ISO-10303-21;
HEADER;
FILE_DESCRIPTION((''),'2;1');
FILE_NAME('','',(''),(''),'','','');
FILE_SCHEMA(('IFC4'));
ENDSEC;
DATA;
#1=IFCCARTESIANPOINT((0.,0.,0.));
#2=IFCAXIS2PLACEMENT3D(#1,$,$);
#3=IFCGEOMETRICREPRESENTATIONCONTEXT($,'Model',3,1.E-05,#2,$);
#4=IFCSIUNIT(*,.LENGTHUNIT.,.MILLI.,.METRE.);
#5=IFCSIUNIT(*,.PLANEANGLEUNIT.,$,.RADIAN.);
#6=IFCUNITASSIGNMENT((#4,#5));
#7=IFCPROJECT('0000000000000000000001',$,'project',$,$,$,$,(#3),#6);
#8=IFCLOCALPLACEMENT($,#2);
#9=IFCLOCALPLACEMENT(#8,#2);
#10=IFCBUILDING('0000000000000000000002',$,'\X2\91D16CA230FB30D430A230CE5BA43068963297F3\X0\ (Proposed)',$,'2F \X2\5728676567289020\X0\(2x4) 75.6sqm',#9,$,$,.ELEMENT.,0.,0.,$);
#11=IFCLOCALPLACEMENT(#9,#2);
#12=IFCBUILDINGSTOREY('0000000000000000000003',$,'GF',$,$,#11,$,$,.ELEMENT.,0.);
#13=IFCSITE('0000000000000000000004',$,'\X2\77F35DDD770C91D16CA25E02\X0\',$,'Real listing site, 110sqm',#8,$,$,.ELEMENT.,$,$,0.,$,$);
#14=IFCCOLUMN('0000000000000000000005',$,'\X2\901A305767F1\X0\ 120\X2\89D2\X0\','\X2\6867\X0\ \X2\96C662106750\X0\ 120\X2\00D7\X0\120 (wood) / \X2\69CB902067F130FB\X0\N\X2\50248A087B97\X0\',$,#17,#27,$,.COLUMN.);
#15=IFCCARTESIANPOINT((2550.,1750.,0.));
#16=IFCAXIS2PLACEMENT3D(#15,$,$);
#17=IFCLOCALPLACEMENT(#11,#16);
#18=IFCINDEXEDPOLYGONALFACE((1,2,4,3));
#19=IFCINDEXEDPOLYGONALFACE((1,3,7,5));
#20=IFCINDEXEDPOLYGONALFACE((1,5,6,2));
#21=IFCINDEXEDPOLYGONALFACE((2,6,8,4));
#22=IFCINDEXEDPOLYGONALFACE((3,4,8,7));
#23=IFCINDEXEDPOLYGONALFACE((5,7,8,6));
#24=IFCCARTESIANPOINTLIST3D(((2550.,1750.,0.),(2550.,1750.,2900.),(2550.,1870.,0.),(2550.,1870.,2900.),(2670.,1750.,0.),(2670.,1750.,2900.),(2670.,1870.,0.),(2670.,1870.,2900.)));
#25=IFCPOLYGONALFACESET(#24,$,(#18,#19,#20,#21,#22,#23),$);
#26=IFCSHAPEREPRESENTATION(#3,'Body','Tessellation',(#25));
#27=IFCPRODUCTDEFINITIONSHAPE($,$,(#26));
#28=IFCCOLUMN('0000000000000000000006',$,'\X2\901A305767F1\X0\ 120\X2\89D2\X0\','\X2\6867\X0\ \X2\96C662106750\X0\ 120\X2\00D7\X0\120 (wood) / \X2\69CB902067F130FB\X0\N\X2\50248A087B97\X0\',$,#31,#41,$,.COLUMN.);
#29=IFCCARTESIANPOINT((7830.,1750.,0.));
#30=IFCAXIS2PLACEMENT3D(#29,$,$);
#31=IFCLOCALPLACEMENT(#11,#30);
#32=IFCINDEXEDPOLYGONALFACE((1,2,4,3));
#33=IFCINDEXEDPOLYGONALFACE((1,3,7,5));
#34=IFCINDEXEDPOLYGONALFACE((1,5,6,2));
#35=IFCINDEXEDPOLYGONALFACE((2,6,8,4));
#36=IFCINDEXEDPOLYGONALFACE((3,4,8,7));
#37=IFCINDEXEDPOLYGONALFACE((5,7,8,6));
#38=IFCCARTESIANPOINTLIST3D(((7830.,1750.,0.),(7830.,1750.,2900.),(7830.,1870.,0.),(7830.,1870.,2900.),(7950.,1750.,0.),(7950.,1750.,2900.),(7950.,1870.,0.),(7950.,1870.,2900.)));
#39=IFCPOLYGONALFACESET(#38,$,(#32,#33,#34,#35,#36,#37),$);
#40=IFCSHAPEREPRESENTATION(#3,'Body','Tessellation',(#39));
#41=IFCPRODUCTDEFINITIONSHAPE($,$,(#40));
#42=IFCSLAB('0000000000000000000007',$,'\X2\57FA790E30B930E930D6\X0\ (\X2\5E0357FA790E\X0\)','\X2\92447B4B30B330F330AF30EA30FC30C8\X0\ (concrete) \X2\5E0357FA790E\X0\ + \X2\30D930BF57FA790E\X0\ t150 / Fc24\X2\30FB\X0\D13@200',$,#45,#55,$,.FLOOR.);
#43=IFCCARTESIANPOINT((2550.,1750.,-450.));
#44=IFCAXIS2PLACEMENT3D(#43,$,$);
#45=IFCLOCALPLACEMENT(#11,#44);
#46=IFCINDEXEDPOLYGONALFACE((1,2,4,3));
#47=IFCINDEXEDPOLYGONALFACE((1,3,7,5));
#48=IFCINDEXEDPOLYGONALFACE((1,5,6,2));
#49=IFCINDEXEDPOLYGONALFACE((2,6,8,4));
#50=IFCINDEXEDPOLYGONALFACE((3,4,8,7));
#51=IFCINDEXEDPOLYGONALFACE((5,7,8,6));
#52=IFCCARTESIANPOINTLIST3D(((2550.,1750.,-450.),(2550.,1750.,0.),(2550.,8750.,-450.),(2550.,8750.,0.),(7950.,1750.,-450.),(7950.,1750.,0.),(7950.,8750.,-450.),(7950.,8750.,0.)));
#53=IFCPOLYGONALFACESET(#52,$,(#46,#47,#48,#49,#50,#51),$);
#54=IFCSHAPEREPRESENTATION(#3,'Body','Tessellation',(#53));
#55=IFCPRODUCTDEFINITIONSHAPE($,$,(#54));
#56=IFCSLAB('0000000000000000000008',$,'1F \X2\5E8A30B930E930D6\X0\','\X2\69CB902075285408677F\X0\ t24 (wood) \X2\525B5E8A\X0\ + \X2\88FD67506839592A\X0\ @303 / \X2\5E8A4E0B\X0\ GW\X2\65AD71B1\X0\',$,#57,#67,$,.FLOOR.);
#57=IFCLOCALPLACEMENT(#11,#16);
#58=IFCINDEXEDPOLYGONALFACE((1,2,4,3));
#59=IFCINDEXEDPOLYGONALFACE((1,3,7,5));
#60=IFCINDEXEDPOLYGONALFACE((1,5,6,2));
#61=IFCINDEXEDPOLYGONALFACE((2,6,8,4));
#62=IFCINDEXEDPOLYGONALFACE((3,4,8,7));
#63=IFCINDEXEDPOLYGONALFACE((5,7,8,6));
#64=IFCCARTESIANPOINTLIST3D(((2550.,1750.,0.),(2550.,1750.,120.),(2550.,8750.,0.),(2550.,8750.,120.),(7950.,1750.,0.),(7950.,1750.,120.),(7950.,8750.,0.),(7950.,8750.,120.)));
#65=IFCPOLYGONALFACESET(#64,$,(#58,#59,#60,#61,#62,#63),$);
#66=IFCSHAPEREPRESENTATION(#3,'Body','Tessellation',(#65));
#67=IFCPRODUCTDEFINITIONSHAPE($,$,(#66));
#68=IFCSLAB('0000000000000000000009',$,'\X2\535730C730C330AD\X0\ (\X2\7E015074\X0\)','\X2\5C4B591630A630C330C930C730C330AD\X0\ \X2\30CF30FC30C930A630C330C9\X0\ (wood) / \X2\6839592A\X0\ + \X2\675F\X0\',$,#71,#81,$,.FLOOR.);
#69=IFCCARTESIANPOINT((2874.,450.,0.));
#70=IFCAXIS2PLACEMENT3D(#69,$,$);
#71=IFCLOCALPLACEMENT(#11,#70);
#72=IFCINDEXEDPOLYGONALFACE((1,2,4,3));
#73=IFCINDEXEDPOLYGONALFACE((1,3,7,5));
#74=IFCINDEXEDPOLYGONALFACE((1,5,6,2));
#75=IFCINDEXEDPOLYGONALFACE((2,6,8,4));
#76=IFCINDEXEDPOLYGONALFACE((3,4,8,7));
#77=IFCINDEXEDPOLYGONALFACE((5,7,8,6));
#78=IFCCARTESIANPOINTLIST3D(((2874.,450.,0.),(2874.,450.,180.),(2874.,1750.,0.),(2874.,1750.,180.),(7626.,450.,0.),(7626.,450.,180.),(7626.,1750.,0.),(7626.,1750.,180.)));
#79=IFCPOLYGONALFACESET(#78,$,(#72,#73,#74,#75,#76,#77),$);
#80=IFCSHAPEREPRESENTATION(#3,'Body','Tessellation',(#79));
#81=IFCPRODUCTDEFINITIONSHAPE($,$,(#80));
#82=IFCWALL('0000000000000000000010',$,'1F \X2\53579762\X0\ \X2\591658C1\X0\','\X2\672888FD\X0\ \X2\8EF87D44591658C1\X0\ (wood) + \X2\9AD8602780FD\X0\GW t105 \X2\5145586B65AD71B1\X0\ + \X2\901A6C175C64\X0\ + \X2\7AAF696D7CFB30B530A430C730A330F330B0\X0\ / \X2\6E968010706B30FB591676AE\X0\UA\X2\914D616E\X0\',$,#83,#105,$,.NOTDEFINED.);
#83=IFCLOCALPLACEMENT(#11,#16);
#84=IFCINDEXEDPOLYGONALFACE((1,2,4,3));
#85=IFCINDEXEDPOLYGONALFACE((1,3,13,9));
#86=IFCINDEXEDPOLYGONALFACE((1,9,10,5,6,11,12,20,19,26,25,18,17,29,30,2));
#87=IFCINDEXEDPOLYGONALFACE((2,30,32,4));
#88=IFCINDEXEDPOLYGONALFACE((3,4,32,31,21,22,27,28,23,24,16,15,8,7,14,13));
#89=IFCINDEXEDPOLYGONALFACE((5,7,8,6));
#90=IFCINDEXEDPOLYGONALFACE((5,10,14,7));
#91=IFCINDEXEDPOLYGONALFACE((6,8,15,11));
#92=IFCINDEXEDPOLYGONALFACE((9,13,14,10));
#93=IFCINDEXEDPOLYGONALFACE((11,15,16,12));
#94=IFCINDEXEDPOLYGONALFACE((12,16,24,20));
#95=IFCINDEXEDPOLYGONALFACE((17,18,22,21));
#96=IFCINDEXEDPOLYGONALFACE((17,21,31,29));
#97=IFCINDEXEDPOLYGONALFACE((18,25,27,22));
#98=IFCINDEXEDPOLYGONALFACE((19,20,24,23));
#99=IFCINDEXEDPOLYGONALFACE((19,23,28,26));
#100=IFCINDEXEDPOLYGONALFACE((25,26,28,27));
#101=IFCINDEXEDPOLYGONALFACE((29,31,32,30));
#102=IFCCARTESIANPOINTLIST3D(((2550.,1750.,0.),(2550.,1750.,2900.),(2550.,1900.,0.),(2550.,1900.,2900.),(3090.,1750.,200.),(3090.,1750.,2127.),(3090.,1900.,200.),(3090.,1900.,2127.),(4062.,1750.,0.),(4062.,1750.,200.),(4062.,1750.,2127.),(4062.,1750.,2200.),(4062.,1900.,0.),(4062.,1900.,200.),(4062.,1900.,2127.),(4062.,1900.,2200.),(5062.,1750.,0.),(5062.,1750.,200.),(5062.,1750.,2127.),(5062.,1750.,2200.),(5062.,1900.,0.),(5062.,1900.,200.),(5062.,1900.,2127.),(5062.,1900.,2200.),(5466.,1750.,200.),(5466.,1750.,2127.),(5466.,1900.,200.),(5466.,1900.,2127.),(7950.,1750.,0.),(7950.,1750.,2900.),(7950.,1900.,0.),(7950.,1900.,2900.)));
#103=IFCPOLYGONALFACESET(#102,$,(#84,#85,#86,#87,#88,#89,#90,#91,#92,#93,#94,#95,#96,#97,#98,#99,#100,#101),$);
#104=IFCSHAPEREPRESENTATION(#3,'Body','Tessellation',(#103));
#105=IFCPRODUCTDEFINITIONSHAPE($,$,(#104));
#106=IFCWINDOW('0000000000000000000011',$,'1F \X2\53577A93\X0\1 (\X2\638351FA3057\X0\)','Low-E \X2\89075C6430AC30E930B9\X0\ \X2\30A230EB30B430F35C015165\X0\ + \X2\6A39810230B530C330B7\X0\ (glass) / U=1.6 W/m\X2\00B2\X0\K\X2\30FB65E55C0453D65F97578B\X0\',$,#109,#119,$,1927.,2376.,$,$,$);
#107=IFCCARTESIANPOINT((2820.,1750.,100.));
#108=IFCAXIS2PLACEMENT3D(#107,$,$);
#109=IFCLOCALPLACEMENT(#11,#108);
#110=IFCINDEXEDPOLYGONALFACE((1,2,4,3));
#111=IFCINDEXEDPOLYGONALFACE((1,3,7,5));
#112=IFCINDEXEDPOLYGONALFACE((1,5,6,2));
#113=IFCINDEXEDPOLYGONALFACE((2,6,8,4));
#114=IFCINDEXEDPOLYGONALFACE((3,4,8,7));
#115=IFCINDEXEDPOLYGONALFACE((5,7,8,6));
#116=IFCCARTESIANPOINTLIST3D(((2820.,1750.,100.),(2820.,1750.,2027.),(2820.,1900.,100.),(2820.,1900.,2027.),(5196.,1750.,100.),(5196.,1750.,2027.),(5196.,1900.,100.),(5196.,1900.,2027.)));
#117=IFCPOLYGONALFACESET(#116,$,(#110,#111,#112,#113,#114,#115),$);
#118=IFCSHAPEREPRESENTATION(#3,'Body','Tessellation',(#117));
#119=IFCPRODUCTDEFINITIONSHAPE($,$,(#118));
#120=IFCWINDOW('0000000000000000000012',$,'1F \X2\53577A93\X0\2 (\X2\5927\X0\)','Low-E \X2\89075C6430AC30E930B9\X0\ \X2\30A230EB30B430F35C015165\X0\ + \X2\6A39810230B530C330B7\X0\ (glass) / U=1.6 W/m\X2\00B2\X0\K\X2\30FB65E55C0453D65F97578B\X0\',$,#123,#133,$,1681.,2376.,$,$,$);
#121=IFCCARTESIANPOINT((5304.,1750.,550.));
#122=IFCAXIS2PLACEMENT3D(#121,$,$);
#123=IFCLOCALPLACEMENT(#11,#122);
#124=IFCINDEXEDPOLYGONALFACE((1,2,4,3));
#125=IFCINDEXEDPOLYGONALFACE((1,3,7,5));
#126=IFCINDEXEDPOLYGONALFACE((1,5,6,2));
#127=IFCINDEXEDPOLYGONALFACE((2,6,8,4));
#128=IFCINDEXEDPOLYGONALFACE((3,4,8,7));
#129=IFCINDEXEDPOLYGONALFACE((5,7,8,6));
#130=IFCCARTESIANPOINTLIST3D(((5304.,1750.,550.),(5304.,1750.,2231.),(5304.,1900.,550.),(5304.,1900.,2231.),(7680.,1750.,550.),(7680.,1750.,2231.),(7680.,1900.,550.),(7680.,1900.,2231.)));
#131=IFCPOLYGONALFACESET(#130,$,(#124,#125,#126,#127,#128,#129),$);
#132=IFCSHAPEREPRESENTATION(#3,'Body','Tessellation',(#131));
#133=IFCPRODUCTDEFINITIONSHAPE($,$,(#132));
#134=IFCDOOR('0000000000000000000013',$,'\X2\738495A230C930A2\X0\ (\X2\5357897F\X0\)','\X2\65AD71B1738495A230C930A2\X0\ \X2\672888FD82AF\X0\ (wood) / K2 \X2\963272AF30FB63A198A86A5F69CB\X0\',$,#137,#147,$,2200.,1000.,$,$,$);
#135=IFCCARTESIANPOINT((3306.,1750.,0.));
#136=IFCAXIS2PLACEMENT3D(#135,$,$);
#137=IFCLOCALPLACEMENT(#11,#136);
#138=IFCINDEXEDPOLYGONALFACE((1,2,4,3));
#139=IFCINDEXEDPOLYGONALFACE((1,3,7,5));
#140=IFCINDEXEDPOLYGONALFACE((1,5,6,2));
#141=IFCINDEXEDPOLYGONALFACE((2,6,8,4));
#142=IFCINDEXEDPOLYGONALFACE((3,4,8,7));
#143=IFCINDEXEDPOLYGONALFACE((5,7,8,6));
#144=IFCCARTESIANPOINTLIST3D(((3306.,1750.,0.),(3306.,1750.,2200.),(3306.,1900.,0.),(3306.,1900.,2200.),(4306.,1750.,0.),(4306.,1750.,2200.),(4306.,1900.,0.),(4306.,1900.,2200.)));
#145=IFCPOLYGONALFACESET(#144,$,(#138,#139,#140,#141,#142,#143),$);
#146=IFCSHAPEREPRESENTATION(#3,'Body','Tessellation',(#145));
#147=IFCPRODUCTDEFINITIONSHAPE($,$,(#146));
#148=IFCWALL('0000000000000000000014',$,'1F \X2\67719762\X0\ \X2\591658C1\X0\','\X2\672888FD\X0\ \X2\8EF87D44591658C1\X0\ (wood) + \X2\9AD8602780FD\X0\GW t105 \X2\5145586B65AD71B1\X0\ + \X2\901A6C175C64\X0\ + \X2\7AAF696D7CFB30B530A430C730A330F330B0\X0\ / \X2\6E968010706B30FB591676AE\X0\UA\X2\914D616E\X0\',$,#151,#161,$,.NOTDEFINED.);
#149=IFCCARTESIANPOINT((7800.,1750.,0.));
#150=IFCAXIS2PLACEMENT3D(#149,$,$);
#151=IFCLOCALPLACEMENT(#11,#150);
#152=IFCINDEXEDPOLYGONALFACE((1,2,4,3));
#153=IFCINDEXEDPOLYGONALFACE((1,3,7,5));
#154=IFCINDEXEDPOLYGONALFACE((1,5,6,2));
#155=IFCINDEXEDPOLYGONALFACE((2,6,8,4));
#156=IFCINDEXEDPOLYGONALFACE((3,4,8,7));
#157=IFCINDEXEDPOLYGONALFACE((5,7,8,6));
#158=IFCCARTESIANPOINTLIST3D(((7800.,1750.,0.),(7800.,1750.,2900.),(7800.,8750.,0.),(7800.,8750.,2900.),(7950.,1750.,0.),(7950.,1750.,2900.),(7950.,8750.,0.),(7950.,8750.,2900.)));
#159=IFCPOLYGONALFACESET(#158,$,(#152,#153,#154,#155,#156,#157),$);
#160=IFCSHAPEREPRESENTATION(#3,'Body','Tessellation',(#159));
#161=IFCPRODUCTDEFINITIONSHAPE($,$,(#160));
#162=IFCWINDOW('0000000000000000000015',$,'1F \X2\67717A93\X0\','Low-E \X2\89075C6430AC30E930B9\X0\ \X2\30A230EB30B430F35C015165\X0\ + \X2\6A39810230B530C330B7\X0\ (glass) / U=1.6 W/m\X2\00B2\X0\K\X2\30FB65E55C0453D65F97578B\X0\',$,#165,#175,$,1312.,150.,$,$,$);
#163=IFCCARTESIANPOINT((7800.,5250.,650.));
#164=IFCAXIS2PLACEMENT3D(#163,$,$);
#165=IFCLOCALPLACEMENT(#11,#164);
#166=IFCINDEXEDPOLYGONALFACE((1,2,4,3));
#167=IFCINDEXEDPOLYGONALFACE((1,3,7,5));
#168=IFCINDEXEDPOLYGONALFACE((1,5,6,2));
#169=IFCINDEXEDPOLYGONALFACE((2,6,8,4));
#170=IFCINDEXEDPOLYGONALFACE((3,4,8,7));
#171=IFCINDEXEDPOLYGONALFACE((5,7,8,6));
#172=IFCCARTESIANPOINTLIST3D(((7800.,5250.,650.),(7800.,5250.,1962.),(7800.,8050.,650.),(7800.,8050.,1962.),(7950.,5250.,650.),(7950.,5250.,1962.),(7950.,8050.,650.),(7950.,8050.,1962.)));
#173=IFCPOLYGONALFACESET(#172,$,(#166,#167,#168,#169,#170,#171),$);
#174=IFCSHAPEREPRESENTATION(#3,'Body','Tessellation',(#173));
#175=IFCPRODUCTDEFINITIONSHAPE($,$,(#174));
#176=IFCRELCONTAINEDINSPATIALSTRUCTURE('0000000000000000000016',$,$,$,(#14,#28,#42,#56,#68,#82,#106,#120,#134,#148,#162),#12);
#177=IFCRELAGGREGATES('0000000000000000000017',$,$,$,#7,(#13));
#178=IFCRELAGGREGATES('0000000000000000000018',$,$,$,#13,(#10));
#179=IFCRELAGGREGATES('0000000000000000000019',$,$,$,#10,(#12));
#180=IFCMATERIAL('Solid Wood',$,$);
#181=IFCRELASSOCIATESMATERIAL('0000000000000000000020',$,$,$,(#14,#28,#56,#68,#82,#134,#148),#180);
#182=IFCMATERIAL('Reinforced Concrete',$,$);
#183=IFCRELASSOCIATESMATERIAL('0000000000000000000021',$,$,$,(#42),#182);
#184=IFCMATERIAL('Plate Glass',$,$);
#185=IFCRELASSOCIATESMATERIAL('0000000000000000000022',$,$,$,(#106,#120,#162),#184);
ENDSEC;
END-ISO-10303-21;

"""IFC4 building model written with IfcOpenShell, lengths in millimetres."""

from ifc_helpers import new_model, si_unit, frame, frame_2d, origin, place, context, project, spatial, rectangle, extrude, material, element, fill, save


model = new_model("IFC4")

# Units and contexts
model_context = context("Model", 3, precision=1e-05, world=origin())
ifc_project = project(units=[si_unit("LENGTHUNIT", "METRE", prefix="MILLI"), si_unit("PLANEANGLEUNIT", "RADIAN")], contexts=[model_context])

# Site, building, storey
site_placement = place(None, origin())
site = spatial("IfcSite", under=ifc_project, at=site_placement, Name="石川県金沢市", ObjectType="Real listing site, 110sqm", CompositionType="ELEMENT", RefElevation=0.0)
building_placement = place(site_placement, origin())
building = spatial("IfcBuilding", under=site, at=building_placement, Name="金沢・ピアノ室と防音 (Proposed)", ObjectType="2F 在来木造(2x4) 75.6sqm", CompositionType="ELEMENT", ElevationOfRefHeight=0.0, ElevationOfTerrain=0.0)
storey_placement = place(building_placement, origin())
storey = spatial("IfcBuildingStorey", under=building, at=storey_placement, Name="GF", CompositionType="ELEMENT", Elevation=0.0)

# Columns
ifc_material_1 = material(Name="Solid Wood")
column_1_placement = place(storey_placement, frame((2550.0, 1750.0, 0.0)))
element("IfcColumn", 1, at=column_1_placement, inside=storey, material=ifc_material_1, Name="通し柱 120角", Description="桧 集成材 120×120 (wood) / 構造柱・N値計算", PredefinedType="COLUMN", context=model_context, shape_type="SweptSolid", body=[
    extrude(rectangle(XDim=120.0, YDim=120.0, at=frame_2d((60.0, 60.0))), frame((2550.0, 1750.0, 0.0)), (0.0, 0.0, 1.0), 2900.0),
])
column_2_placement = place(storey_placement, frame((7830.0, 1750.0, 0.0)))
element("IfcColumn", 2, at=column_2_placement, inside=storey, material=ifc_material_1, Name="通し柱 120角", Description="桧 集成材 120×120 (wood) / 構造柱・N値計算", PredefinedType="COLUMN", context=model_context, shape_type="SweptSolid", body=[
    extrude(rectangle(XDim=120.0, YDim=120.0, at=frame_2d((60.0, 60.0))), frame((7830.0, 1750.0, 0.0)), (0.0, 0.0, 1.0), 2900.0),
])

# Slabs
ifc_material_2 = material(Name="Reinforced Concrete")
slab_1_placement = place(storey_placement, frame((2550.0, 1750.0, -450.0)))
element("IfcSlab", 3, at=slab_1_placement, inside=storey, material=ifc_material_2, Name="基礎スラブ (布基礎)", Description="鉄筋コンクリート (concrete) 布基礎 + ベタ基礎 t150 / Fc24・D13@200", PredefinedType="FLOOR", context=model_context, shape_type="SweptSolid", body=[
    extrude(rectangle(XDim=5400.0, YDim=7000.0, at=frame_2d((2700.0, 3500.0))), frame((2550.0, 1750.0, -450.0)), (0.0, 0.0, 1.0), 450.0),
])
slab_2_placement = place(storey_placement, frame((2550.0, 1750.0, 0.0)))
element("IfcSlab", 4, at=slab_2_placement, inside=storey, material=ifc_material_1, Name="1F 床スラブ", Description="構造用合板 t24 (wood) 剛床 + 製材根太 @303 / 床下 GW断熱", PredefinedType="FLOOR", context=model_context, shape_type="SweptSolid", body=[
    extrude(rectangle(XDim=5400.0, YDim=7000.0, at=frame_2d((2700.0, 3500.0))), frame((2550.0, 1750.0, 0.0)), (0.0, 0.0, 1.0), 120.0),
])
slab_3_placement = place(storey_placement, frame((2874.0, 450.0, 0.0)))
element("IfcSlab", 5, at=slab_3_placement, inside=storey, material=ifc_material_1, Name="南デッキ (縁側)", Description="屋外ウッドデッキ ハードウッド (wood) / 根太 + 束", PredefinedType="FLOOR", context=model_context, shape_type="SweptSolid", body=[
    extrude(rectangle(XDim=4752.0, YDim=1300.0, at=frame_2d((2376.0, 650.0))), frame((2874.0, 450.0, 0.0)), (0.0, 0.0, 1.0), 180.0),
])

# Wall, openings, windows, door
wall_1_placement = place(storey_placement, frame((2550.0, 1750.0, 0.0)))
wall_1 = element("IfcWall", 6, at=wall_1_placement, inside=storey, material=ifc_material_1, Name="1F 南面 外壁", Description="木製 軸組外壁 (wood) + 高性能GW t105 充填断熱 + 通気層 + 窯業系サイディング / 準耐火・外皮UA配慮", PredefinedType="NOTDEFINED", context=model_context, shape_type="SweptSolid", body=[
    extrude(rectangle(XDim=5400.0, YDim=150.0, at=frame_2d((2700.0, 75.0))), frame((2550.0, 1750.0, 0.0)), (0.0, 0.0, 1.0), 2900.0),
])
opening_1_placement = place(storey_placement, frame((2820.0, 1750.0, 100.0)))
opening_1 = element("IfcOpeningElement", 7, at=opening_1_placement, cuts=wall_1, PredefinedType="NOTDEFINED", context=model_context, shape_type="SweptSolid", body=[
    extrude(rectangle(XDim=2376.0, YDim=150.0, at=frame_2d((1188.0, 75.0))), frame((2820.0, 1750.0, 100.0)), (0.0, 0.0, 1.0), 1927.0),
])
opening_2_placement = place(storey_placement, frame((5304.0, 1750.0, 550.0)))
opening_2 = element("IfcOpeningElement", 8, at=opening_2_placement, cuts=wall_1, PredefinedType="NOTDEFINED", context=model_context, shape_type="SweptSolid", body=[
    extrude(rectangle(XDim=2376.0, YDim=150.0, at=frame_2d((1188.0, 75.0))), frame((5304.0, 1750.0, 550.0)), (0.0, 0.0, 1.0), 1681.0),
])
opening_3_placement = place(storey_placement, frame((3306.0, 1750.0, 0.0)))
opening_3 = element("IfcOpeningElement", 9, at=opening_3_placement, cuts=wall_1, PredefinedType="NOTDEFINED", context=model_context, shape_type="SweptSolid", body=[
    extrude(rectangle(XDim=1000.0, YDim=150.0, at=frame_2d((500.0, 75.0))), frame((3306.0, 1750.0, 0.0)), (0.0, 0.0, 1.0), 2200.0),
])
ifc_material_3 = material(Name="Plate Glass")
window_1_placement = place(storey_placement, frame((2820.0, 1750.0, 100.0)))
window_1 = element("IfcWindow", 10, at=window_1_placement, inside=storey, material=ifc_material_3, Name="1F 南窓1 (掃出し)", Description="Low-E 複層ガラス アルゴン封入 + 樹脂サッシ (glass) / U=1.6 W/m²K・日射取得型", OverallHeight=1927.0, OverallWidth=2376.0, context=model_context, shape_type="SweptSolid", body=[
    extrude(rectangle(XDim=2376.0, YDim=150.0, at=frame_2d((1188.0, 75.0))), frame((2820.0, 1750.0, 100.0)), (0.0, 0.0, 1.0), 1927.0),
])
fill(opening_1, window_1)
window_2_placement = place(storey_placement, frame((5304.0, 1750.0, 550.0)))
window_2 = element("IfcWindow", 11, at=window_2_placement, inside=storey, material=ifc_material_3, Name="1F 南窓2 (大)", Description="Low-E 複層ガラス アルゴン封入 + 樹脂サッシ (glass) / U=1.6 W/m²K・日射取得型", OverallHeight=1681.0, OverallWidth=2376.0, context=model_context, shape_type="SweptSolid", body=[
    extrude(rectangle(XDim=2376.0, YDim=150.0, at=frame_2d((1188.0, 75.0))), frame((5304.0, 1750.0, 550.0)), (0.0, 0.0, 1.0), 1681.0),
])
fill(opening_2, window_2)
door_placement = place(storey_placement, frame((3306.0, 1750.0, 0.0)))
door = element("IfcDoor", 12, at=door_placement, inside=storey, material=ifc_material_1, Name="玄関ドア (南西)", Description="断熱玄関ドア 木製芯 (wood) / K2 防犯・採風機構", OverallHeight=2200.0, OverallWidth=1000.0, context=model_context, shape_type="SweptSolid", body=[
    extrude(rectangle(XDim=1000.0, YDim=150.0, at=frame_2d((500.0, 75.0))), frame((3306.0, 1750.0, 0.0)), (0.0, 0.0, 1.0), 2200.0),
])
fill(opening_3, door)

# Wall, opening, window
wall_2_placement = place(storey_placement, frame((7800.0, 1750.0, 0.0)))
wall_2 = element("IfcWall", 13, at=wall_2_placement, inside=storey, material=ifc_material_1, Name="1F 東面 外壁", Description="木製 軸組外壁 (wood) + 高性能GW t105 充填断熱 + 通気層 + 窯業系サイディング / 準耐火・外皮UA配慮", PredefinedType="NOTDEFINED", context=model_context, shape_type="SweptSolid", body=[
    extrude(rectangle(XDim=150.0, YDim=7000.0, at=frame_2d((75.0, 3500.0))), frame((7800.0, 1750.0, 0.0)), (0.0, 0.0, 1.0), 2900.0),
])
opening_4_placement = place(storey_placement, frame((7800.0, 5250.0, 650.0)))
opening_4 = element("IfcOpeningElement", 14, at=opening_4_placement, cuts=wall_2, PredefinedType="NOTDEFINED", context=model_context, shape_type="SweptSolid", body=[
    extrude(rectangle(XDim=150.0, YDim=2800.0, at=frame_2d((75.0, 1400.0))), frame((7800.0, 5250.0, 650.0)), (0.0, 0.0, 1.0), 1312.0),
])
window_3_placement = place(storey_placement, frame((7800.0, 5250.0, 650.0)))
window_3 = element("IfcWindow", 15, at=window_3_placement, inside=storey, material=ifc_material_3, Name="1F 東窓", Description="Low-E 複層ガラス アルゴン封入 + 樹脂サッシ (glass) / U=1.6 W/m²K・日射取得型", OverallHeight=1312.0, OverallWidth=150.0, context=model_context, shape_type="SweptSolid", body=[
    extrude(rectangle(XDim=150.0, YDim=2800.0, at=frame_2d((75.0, 1400.0))), frame((7800.0, 5250.0, 650.0)), (0.0, 0.0, 1.0), 1312.0),
])
fill(opening_4, window_3)

save(model, "model.ifc")
